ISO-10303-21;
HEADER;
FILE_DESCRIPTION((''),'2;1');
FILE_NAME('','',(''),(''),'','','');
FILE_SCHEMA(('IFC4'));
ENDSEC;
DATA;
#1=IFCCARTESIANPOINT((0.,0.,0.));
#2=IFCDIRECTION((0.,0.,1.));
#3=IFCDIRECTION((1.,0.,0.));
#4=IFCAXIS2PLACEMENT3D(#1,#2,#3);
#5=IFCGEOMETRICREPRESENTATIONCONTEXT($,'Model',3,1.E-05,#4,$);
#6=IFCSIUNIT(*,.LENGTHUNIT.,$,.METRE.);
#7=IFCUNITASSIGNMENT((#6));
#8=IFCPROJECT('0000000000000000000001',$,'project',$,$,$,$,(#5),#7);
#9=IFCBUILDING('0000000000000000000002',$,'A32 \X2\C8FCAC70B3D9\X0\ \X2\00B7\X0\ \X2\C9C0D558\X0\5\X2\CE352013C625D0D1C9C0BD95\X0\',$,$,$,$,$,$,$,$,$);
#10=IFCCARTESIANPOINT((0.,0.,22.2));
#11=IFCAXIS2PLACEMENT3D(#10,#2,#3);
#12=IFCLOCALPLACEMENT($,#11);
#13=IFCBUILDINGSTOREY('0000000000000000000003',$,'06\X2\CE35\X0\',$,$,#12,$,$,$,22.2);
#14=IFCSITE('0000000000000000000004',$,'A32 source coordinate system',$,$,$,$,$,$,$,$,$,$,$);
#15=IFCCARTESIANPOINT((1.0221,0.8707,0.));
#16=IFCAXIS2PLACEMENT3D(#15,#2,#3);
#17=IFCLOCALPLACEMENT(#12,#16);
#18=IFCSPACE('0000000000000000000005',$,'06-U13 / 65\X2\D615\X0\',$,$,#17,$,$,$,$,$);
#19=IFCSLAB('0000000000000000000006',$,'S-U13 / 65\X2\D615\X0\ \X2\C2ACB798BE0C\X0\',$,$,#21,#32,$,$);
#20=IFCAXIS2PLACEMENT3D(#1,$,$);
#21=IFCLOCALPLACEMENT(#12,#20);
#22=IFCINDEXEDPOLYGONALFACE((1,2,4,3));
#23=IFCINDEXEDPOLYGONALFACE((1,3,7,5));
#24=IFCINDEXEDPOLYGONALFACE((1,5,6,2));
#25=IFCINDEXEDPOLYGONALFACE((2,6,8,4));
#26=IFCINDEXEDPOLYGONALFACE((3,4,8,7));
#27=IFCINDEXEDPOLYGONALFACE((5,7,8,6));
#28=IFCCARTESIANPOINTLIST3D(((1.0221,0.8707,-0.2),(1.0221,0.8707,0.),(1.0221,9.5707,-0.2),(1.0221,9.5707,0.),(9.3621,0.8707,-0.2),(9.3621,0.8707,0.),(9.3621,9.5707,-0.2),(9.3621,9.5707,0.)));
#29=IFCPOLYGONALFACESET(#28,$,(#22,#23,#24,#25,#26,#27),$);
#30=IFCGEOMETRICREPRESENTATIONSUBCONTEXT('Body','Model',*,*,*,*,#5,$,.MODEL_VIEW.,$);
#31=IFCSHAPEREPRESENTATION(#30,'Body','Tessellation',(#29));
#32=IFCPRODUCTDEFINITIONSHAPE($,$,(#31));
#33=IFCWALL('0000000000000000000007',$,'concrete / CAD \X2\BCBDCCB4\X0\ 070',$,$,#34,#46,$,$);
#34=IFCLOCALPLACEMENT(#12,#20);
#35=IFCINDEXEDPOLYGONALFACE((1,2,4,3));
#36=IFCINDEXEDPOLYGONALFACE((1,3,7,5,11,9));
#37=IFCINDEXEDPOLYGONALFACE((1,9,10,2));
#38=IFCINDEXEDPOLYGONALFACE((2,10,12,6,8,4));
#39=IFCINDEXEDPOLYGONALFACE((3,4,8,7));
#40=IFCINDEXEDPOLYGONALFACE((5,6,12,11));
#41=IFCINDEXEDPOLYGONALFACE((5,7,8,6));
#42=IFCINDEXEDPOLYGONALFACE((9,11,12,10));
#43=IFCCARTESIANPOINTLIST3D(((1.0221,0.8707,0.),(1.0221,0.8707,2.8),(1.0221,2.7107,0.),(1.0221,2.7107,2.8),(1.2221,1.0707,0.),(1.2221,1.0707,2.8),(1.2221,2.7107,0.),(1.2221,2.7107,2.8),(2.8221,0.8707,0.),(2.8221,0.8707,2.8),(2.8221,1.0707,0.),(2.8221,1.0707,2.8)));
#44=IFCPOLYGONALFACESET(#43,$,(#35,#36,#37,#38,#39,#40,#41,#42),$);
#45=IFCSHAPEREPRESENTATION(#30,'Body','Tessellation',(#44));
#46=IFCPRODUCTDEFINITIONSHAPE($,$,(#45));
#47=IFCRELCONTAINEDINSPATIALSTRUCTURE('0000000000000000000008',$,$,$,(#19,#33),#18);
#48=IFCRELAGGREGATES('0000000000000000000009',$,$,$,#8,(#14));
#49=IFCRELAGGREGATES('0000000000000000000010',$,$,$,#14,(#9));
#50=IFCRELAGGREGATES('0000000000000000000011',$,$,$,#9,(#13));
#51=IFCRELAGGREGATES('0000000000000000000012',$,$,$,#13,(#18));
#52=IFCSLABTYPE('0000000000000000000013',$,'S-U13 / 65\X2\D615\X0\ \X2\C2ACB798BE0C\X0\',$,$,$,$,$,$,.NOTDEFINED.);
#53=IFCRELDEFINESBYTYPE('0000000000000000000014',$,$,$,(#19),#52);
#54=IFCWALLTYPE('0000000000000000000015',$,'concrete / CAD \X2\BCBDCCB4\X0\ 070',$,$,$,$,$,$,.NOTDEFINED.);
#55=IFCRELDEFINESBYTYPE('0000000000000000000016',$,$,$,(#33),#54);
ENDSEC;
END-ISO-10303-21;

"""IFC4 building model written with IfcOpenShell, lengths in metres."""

from ifc_helpers import new_model, si_unit, frame, origin, origin_with_axes, place, context, subcontext, project, spatial, polyline, outline, extrude, source, transform, mapped, type_object, type_shapes, element, save


model = new_model("IFC4")

# Units and contexts
model_context = context("Model", 3, precision=1e-05, world=origin_with_axes())
body_context = subcontext(model_context, "Body", "Model", "MODEL_VIEW")
ifc_project = project(units=[si_unit("LENGTHUNIT", "METRE")], contexts=[model_context])

# Site, building, storey, space
storey_placement = place(None, frame((0.0, 0.0, 22.2), z_axis=(0.0, 0.0, 1.0), x_axis=(1.0, 0.0, 0.0)))
space_placement = place(storey_placement, frame((1.0221, 0.8707, 0.0), z_axis=(0.0, 0.0, 1.0), x_axis=(1.0, 0.0, 0.0)))
site = spatial("IfcSite", under=ifc_project, Name="A32 source coordinate system")
building = spatial("IfcBuilding", under=site, Name="A32 주거동 · 지하5층–옥탑지붕")
storey = spatial("IfcBuildingStorey", under=building, at=storey_placement, Name="06층", Elevation=22.2)
space = spatial("IfcSpace", under=storey, at=space_placement, Name="06-U13 / 65형")

# Slab
slab_type = type_object("IfcSlabType", Name="S-U13 / 65형 슬래브", PredefinedType="NOTDEFINED")
shared_shape_1 = source(origin(), body_context, "Body", "SweptSolid", [
    extrude(outline(polyline([(0.0, 0.0), (0.0, 8.7), (8.34, 8.7), (8.34, 0.0), (0.0, 0.0)])), frame((0.0, 0.0, -0.2)), (0.0, 0.0, 1.0), 0.2),
])
type_shapes(slab_type, [shared_shape_1])
slab_placement = place(space_placement, origin_with_axes())
element("IfcSlab", 1, at=slab_placement, inside=space, type_object=slab_type, Name="S-U13 / 65형 슬래브", context=body_context, shape_type="MappedRepresentation", body=[
    mapped(shared_shape_1, transform((0.0, 0.0, 0.0), scale=1.0)),
])

# Wall
wall_type_1 = type_object("IfcWallType", Name="concrete / CAD 벽체 070", PredefinedType="NOTDEFINED")
shared_shape_2 = source(origin(), body_context, "Body", "SweptSolid", [
    extrude(outline(polyline([(0.2, 1.84), (0.2, 0.2), (1.8, 0.2), (1.8, 0.0), (0.0, 0.0), (0.0, 1.84), (0.2, 1.84)])), origin(), (0.0, 0.0, 1.0), 2.8),
])
type_shapes(wall_type_1, [shared_shape_2])
wall_1_placement = place(space_placement, origin_with_axes())
element("IfcWall", 2, at=wall_1_placement, inside=space, type_object=wall_type_1, Name="concrete / CAD 벽체 070", context=body_context, shape_type="MappedRepresentation", body=[
    mapped(shared_shape_2, transform((0.0, 0.0, 0.0), scale=1.0)),
])

save(model, "model.ifc")
